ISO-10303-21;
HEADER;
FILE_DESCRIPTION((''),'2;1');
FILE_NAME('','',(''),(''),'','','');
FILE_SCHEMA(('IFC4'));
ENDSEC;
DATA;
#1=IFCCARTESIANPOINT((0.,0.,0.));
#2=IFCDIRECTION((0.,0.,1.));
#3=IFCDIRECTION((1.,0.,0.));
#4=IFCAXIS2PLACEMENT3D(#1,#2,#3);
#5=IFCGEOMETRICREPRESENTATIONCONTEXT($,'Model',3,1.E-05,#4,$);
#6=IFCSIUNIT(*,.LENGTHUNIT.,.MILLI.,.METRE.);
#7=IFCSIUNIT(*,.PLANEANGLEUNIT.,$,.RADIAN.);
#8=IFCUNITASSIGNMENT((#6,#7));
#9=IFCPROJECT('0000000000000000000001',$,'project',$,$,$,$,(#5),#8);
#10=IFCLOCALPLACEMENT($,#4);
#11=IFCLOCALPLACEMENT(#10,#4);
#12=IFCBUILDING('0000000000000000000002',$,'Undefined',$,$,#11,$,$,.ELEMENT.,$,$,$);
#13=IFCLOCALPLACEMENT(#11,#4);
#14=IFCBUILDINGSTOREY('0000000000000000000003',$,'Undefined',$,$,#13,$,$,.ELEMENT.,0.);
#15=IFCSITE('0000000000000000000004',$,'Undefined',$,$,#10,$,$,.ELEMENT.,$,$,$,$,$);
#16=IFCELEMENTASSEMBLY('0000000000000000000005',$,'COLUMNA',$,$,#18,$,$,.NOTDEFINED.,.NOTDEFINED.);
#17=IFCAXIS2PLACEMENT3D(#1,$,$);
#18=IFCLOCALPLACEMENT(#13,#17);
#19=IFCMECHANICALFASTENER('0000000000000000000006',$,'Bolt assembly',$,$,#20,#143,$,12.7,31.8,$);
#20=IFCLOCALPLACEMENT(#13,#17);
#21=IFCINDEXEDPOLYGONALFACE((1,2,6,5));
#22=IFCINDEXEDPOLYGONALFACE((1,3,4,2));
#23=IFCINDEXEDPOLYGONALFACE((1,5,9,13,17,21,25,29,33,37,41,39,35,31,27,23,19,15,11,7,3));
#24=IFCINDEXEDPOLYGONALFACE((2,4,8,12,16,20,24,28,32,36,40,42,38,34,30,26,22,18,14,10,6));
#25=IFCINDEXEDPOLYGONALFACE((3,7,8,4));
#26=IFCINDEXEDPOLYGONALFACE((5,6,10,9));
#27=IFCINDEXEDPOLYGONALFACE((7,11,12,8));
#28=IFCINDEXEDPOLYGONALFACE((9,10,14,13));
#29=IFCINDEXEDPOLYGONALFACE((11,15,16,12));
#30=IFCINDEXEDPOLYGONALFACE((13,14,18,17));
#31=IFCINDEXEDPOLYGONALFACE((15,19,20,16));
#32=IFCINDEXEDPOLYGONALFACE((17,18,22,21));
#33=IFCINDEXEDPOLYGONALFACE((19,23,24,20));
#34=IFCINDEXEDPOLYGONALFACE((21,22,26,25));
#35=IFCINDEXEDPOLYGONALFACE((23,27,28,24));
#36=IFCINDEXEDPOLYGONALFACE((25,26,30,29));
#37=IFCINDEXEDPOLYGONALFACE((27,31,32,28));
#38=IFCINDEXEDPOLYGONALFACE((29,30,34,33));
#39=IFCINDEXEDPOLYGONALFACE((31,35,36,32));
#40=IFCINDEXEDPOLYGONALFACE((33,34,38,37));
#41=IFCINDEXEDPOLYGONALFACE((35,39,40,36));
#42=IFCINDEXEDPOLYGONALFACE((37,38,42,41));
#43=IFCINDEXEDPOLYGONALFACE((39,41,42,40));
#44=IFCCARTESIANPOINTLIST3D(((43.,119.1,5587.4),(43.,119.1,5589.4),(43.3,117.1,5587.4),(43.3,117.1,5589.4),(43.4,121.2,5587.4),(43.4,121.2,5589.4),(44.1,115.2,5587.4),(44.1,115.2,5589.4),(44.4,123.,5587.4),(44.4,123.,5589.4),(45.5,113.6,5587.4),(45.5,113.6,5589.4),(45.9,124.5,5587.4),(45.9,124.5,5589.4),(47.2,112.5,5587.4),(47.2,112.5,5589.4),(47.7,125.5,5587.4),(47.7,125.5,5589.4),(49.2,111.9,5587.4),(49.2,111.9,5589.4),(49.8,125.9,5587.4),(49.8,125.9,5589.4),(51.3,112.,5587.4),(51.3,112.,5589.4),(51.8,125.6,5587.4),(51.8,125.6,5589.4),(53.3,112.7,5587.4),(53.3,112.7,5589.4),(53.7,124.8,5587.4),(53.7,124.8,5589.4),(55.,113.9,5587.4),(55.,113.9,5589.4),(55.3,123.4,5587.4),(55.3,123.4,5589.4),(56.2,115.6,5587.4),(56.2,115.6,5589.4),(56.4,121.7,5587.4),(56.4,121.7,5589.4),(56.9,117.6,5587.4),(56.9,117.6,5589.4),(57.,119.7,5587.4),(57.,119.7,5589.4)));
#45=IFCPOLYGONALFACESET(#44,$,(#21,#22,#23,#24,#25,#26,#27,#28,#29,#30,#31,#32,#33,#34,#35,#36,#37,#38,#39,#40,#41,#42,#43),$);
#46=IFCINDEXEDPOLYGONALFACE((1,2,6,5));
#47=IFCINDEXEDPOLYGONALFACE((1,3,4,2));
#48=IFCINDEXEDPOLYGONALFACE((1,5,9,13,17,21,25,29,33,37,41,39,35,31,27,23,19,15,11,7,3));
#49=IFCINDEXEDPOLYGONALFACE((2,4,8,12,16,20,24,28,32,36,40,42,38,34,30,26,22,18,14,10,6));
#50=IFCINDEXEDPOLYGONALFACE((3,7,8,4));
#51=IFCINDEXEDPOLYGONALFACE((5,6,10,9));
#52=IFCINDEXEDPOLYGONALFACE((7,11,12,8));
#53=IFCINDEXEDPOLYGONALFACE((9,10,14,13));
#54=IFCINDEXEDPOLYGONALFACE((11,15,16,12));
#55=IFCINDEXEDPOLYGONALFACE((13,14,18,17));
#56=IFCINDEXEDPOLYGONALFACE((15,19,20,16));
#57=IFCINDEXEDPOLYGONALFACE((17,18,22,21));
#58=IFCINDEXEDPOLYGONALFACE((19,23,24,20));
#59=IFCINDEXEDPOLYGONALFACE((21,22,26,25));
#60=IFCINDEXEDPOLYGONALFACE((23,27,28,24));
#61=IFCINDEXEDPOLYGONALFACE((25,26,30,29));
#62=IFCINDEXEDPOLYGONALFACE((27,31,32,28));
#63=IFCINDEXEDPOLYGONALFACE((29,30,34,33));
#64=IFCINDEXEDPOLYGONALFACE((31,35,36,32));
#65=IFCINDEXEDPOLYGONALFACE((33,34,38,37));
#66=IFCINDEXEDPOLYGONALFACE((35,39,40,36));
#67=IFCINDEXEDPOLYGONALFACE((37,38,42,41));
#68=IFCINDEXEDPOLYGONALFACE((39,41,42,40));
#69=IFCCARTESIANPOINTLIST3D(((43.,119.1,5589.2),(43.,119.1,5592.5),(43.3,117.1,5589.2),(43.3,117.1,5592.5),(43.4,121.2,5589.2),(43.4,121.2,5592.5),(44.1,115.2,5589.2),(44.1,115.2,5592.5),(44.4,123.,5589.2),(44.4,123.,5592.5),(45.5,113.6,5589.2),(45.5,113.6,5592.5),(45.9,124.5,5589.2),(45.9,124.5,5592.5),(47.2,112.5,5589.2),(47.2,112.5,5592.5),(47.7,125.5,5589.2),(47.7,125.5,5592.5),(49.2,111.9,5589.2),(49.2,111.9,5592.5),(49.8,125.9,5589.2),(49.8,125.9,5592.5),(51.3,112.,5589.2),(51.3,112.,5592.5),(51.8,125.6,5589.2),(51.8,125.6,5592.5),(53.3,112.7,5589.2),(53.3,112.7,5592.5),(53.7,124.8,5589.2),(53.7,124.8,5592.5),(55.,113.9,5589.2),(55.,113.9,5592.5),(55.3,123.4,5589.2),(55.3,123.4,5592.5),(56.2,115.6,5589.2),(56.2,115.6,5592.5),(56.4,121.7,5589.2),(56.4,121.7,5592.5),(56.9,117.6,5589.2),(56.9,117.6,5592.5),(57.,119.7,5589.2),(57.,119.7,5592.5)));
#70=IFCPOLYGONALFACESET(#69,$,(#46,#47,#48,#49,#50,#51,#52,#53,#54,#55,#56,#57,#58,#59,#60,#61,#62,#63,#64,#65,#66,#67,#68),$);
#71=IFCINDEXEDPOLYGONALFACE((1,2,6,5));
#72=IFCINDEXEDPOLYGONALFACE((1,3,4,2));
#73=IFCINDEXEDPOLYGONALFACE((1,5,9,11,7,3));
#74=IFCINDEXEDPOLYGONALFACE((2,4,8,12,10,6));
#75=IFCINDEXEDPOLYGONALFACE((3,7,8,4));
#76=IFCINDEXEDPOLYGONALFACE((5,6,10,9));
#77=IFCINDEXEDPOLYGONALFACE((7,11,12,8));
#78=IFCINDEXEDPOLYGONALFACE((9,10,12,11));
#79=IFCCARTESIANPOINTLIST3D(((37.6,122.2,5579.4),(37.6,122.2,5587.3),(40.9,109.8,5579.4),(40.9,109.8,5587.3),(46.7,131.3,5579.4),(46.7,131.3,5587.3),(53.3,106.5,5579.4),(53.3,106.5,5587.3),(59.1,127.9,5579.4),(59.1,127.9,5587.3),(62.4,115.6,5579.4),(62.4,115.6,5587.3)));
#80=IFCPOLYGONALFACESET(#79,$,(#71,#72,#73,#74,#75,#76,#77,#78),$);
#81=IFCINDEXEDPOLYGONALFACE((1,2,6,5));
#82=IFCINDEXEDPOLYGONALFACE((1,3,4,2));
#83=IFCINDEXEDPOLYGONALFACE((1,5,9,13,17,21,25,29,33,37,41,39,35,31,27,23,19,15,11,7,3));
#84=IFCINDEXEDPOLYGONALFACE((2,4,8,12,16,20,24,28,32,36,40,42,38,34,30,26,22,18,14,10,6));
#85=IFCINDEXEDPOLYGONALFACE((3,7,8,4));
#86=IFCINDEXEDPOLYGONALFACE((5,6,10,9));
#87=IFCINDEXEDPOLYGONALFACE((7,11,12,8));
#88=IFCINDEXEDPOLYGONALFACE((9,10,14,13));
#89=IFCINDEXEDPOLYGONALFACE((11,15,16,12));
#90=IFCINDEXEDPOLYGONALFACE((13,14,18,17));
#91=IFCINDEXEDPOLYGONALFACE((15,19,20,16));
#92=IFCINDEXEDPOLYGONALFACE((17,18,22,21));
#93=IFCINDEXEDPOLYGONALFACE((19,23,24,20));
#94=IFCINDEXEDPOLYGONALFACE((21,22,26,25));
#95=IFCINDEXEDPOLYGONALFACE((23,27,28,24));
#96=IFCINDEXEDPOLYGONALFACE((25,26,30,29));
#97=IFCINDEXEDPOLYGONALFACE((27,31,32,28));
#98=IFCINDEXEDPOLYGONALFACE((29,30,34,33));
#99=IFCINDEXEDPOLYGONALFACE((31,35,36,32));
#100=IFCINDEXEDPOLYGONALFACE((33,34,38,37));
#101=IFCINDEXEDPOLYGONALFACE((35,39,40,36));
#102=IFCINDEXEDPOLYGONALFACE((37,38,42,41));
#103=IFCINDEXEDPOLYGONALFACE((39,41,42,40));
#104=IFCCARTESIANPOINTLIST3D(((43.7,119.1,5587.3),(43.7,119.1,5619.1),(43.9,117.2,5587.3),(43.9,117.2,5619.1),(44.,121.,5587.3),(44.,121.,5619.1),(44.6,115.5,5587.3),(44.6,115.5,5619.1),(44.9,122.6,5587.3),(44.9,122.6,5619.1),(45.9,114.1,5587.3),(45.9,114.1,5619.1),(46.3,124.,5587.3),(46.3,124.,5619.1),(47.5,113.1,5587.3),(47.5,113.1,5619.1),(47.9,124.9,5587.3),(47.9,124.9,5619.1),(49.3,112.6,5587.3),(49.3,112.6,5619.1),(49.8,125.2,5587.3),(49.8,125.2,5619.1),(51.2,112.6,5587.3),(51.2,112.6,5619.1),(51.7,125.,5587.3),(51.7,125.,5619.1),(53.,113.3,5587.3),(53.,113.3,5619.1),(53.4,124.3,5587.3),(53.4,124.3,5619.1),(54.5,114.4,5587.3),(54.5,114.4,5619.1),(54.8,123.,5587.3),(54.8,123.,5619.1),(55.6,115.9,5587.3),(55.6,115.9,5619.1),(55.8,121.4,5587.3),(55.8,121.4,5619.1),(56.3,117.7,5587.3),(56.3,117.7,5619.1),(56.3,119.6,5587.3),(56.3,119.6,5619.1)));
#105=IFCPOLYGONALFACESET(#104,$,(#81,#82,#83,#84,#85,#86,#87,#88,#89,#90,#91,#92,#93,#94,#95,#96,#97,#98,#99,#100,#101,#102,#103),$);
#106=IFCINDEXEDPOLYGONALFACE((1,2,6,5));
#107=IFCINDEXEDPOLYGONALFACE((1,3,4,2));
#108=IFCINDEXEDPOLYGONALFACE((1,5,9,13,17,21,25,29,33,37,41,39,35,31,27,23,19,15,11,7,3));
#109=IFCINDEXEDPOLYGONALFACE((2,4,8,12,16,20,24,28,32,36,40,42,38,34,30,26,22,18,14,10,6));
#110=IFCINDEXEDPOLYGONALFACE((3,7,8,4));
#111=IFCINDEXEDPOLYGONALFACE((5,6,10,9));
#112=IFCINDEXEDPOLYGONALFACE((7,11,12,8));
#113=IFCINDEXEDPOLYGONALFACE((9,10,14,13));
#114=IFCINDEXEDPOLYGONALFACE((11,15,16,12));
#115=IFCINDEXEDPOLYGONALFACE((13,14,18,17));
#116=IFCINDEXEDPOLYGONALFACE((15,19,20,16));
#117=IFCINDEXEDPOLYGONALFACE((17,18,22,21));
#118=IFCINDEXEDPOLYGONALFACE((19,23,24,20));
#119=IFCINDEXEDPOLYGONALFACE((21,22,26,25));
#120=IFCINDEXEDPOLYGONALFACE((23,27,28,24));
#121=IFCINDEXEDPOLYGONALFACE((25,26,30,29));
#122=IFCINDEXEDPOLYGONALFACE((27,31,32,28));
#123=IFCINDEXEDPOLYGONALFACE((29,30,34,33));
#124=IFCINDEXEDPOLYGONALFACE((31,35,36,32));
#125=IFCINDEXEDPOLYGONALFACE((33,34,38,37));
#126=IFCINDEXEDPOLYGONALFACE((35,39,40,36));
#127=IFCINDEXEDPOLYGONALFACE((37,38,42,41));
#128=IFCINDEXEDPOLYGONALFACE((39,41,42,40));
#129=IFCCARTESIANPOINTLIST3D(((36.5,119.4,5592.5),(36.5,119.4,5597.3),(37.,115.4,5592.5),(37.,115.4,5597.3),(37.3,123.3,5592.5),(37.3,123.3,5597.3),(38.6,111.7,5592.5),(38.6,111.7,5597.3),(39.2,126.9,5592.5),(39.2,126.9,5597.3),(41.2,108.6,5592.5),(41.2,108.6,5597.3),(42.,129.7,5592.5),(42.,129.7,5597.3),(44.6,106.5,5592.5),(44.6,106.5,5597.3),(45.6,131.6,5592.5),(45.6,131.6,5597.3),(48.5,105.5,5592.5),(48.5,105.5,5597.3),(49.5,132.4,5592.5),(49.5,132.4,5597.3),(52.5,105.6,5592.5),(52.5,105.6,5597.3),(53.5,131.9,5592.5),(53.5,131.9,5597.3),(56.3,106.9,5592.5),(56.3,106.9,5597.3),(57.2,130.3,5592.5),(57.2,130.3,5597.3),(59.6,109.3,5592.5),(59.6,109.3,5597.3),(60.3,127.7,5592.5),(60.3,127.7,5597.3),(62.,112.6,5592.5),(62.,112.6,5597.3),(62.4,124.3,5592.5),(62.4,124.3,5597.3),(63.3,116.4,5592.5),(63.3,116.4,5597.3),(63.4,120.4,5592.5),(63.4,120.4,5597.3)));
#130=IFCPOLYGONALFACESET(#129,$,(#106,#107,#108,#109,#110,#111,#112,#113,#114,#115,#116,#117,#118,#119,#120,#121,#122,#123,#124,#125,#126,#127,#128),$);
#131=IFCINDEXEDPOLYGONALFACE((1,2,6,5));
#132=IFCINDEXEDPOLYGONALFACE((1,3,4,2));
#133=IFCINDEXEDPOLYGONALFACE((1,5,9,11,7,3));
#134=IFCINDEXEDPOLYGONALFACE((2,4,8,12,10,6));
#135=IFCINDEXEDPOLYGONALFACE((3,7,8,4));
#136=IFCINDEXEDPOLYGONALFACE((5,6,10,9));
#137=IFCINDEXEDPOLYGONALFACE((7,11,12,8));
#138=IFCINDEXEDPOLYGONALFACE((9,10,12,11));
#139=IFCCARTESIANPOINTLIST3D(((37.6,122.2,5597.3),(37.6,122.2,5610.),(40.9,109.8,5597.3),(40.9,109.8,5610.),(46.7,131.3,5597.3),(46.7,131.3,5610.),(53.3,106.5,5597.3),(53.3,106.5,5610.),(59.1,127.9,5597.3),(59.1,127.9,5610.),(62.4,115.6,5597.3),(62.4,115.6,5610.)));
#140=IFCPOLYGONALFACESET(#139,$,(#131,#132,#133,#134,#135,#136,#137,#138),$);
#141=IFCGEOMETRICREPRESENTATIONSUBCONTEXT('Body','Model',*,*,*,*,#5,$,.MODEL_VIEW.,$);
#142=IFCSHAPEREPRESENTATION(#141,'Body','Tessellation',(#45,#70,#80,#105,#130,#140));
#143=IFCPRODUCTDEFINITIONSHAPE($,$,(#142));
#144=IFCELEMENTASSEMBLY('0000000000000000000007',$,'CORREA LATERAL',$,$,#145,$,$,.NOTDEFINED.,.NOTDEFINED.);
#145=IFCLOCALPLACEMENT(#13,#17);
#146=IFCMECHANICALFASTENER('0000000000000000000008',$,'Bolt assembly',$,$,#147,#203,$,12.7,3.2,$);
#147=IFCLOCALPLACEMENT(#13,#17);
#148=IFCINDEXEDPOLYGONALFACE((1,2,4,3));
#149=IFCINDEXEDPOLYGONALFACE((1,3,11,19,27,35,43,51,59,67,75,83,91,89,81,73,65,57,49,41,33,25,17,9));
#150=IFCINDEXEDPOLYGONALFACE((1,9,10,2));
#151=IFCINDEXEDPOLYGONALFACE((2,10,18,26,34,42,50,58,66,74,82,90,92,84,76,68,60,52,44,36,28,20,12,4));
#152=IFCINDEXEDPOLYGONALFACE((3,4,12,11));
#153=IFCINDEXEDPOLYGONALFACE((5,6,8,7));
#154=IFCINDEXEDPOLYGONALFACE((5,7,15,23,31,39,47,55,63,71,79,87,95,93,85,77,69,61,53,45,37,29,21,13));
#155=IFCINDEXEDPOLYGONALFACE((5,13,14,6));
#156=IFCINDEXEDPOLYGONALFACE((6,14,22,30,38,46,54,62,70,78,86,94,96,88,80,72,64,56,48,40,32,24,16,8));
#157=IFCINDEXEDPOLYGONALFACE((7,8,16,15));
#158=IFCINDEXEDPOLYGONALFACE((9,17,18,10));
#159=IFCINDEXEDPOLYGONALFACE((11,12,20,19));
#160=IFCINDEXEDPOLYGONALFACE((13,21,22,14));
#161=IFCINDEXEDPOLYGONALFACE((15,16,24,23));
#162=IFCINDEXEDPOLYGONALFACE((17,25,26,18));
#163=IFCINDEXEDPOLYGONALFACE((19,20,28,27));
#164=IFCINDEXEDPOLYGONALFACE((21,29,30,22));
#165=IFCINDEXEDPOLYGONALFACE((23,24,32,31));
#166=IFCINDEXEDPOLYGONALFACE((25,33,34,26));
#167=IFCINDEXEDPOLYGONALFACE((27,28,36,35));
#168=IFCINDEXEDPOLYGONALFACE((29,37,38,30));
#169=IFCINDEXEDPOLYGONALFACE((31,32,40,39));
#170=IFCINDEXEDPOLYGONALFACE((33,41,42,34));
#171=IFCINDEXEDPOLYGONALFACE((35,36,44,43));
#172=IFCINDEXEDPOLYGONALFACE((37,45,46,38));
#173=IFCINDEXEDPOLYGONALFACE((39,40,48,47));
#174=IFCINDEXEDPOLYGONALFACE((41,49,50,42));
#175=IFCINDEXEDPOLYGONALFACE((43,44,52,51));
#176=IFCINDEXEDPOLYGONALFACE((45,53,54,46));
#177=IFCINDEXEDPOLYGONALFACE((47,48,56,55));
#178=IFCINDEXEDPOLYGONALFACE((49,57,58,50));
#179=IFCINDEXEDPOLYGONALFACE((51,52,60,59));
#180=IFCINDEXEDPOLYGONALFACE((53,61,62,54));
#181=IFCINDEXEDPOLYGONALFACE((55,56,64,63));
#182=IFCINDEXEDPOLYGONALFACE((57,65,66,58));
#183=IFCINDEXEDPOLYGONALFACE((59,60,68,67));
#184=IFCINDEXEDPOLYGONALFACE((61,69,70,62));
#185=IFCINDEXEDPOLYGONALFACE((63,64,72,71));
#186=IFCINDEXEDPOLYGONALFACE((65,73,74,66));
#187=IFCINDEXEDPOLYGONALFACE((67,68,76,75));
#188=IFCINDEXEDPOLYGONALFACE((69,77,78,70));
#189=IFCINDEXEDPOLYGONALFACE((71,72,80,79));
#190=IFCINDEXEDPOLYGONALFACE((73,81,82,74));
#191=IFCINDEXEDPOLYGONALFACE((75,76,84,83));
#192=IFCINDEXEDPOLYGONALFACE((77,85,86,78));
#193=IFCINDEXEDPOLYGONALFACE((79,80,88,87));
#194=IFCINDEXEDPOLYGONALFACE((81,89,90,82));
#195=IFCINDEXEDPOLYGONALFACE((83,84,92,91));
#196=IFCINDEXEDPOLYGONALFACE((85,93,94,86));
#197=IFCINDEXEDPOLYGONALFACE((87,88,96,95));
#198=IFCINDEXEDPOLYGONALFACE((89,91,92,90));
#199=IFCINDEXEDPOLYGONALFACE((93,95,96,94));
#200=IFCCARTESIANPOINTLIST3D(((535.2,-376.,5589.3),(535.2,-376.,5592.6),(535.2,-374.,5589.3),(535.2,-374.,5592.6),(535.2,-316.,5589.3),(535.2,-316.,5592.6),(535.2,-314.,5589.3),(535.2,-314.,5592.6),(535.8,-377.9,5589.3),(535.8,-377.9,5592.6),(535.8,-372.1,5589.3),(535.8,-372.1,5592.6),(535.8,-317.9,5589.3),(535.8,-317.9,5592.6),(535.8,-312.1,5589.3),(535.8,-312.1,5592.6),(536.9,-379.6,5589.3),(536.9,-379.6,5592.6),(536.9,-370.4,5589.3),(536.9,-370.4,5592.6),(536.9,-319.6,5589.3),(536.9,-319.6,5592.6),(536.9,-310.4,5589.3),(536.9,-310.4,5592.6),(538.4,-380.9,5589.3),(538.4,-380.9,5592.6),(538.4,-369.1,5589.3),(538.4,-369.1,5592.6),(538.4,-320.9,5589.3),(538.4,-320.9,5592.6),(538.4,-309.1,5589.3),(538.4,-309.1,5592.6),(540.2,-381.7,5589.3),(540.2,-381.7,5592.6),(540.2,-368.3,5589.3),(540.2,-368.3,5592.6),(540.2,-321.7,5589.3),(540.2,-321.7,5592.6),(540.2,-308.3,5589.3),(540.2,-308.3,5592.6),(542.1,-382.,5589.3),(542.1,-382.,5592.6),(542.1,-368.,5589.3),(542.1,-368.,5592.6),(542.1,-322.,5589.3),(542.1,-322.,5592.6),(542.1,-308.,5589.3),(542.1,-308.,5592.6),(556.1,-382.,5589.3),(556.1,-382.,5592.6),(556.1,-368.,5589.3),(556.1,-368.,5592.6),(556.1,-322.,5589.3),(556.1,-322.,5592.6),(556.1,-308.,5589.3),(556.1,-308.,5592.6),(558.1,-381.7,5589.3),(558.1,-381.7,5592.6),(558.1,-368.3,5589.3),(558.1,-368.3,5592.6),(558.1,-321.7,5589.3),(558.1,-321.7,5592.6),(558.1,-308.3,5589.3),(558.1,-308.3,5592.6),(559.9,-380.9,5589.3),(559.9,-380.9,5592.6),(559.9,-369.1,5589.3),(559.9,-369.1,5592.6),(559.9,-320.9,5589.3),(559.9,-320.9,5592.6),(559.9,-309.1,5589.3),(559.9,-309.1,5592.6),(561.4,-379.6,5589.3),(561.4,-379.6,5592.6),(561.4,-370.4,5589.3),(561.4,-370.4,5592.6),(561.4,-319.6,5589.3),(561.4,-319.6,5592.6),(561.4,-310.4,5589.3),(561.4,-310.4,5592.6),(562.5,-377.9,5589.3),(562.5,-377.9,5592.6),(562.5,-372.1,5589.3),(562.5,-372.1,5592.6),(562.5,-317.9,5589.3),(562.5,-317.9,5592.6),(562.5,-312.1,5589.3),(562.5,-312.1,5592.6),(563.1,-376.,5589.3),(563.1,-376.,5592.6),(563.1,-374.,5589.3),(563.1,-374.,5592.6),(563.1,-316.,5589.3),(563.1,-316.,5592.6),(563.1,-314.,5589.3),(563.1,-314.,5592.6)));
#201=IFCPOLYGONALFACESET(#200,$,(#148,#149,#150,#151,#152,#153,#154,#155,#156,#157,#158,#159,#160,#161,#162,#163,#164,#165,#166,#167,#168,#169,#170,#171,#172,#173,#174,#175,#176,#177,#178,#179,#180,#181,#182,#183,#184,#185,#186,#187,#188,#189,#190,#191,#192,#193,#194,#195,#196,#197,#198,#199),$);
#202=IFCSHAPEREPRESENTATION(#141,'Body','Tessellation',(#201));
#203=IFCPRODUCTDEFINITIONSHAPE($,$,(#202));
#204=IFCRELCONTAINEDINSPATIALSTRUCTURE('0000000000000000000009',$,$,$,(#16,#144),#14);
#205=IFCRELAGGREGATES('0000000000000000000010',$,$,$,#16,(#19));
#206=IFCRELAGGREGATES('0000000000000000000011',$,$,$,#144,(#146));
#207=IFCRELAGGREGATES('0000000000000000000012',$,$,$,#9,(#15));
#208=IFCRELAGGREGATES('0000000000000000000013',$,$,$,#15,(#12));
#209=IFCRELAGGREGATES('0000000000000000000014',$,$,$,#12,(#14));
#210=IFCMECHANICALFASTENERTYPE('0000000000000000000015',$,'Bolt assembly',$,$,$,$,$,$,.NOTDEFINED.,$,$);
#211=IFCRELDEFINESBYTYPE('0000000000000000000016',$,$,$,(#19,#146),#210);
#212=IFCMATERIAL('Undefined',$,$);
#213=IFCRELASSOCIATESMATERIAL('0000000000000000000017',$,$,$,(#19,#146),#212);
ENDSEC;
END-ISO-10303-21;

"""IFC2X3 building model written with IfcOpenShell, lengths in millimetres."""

from ifc_helpers import new_model, si_unit, frame, frame_2d, origin_with_axes, origin_2d_with_axis, place, context, subcontext, project, spatial, polyline, circle_curve, parameter, trimmed, segment, composite_curve, circle, outline, extrude, source, transform, mapped, material, type_object, element, aggregate, save


model = new_model("IFC2X3")

# Units and contexts
model_context = context("Model", 3, precision=1e-05, world=origin_with_axes())
body_context = subcontext(model_context, "Body", "Model", "MODEL_VIEW")
ifc_project = project(units=[si_unit("LENGTHUNIT", "METRE", prefix="MILLI"), si_unit("PLANEANGLEUNIT", "RADIAN")], contexts=[model_context])

# Site, building, storey
site_placement = place(None, origin_with_axes())
site = spatial("IfcSite", under=ifc_project, at=site_placement, Name="Undefined", CompositionType="ELEMENT")
building_placement = place(site_placement, origin_with_axes())
building = spatial("IfcBuilding", under=site, at=building_placement, Name="Undefined", CompositionType="ELEMENT")
storey_placement = place(building_placement, origin_with_axes())
storey = spatial("IfcBuildingStorey", under=building, at=storey_placement, Name="Undefined", CompositionType="ELEMENT", Elevation=0.0)

# Element assembly
assembly_1_placement = place(storey_placement, origin_with_axes())
assembly_1 = element("IfcElementAssembly", 1, at=assembly_1_placement, inside=storey, Name="COLUMNA", AssemblyPlace="NOTDEFINED", PredefinedType="NOTDEFINED")

# Shared definitions
ifc_material_1 = material(Name="Undefined")
mechanical_fastener_type = type_object("IfcMechanicalFastenerType", Name="Bolt assembly")

# Mechanical fastener
shared_shape_1 = source(origin_with_axes(), body_context, "Body", "SweptSolid", [
    extrude(circle(Radius=7.0, at=origin_2d_with_axis()), frame((0.0, -1.9, 0.0), z_axis=(0.0, 1.0, 0.0), x_axis=(1.0, 0.0, 0.0)), (0.0, 0.0, 1.0), 2.0),
    extrude(circle(Radius=7.0, at=origin_2d_with_axis()), frame((0.0, -0.1, 0.0), z_axis=(0.0, 1.0, 0.0), x_axis=(1.0, 0.0, 0.0)), (0.0, 0.0, 1.0), 3.3),
    extrude(outline(polyline([(11.1, -6.4), (11.1, 6.4), (0.0, 12.8), (-11.1, 6.4), (-11.1, -6.4), (0.0, -12.8), (11.1, -6.4)])), frame((0.0, -9.9, 0.0), z_axis=(0.0, 1.0, 0.0), x_axis=(1.0, 0.0, 0.0)), (0.0, 0.0, 1.0), 7.9),
    extrude(circle(Radius=6.3, at=origin_2d_with_axis()), frame((0.0, -2.0, 0.0), z_axis=(0.0, 1.0, 0.0), x_axis=(1.0, 0.0, 0.0)), (0.0, 0.0, 1.0), 31.8),
    extrude(circle(Radius=13.5, at=origin_2d_with_axis()), frame((0.0, 3.2, 0.0), z_axis=(0.0, 1.0, 0.0), x_axis=(1.0, 0.0, 0.0)), (0.0, 0.0, 1.0), 4.8),
    extrude(outline(polyline([(11.1, -6.4), (11.1, 6.4), (0.0, 12.8), (-11.1, 6.4), (-11.1, -6.4), (0.0, -12.8), (11.1, -6.4)])), frame((0.0, 8.0, 0.0), z_axis=(0.0, 1.0, 0.0), x_axis=(1.0, 0.0, 0.0)), (0.0, 0.0, 1.0), 12.7),
])
mechanical_fastener_1_placement = place(assembly_1_placement, frame((50.0, 118.9, 5589.3), z_axis=(-0.707106, -0.707107, 0.000005), x_axis=(0.707107, -0.707107, 0.000005)))
mechanical_fastener_1 = element("IfcMechanicalFastener", 2, at=mechanical_fastener_1_placement, type_object=mechanical_fastener_type, material=ifc_material_1, Name="Bolt assembly", NominalDiameter=12.7, NominalLength=31.8, context=body_context, shape_type="MappedRepresentation", body=[
    mapped(shared_shape_1, transform((0.0, 0.0, 0.0))),
])
aggregate(assembly_1, [mechanical_fastener_1])

# Element assembly, mechanical fastener
assembly_2_placement = place(storey_placement, origin_with_axes())
assembly_2 = element("IfcElementAssembly", 3, at=assembly_2_placement, inside=storey, Name="CORREA LATERAL", AssemblyPlace="NOTDEFINED", PredefinedType="NOTDEFINED")
shared_shape_2 = source(origin_with_axes(), body_context, "Body", "SweptSolid", [
    extrude(outline(composite_curve([segment(polyline([(7.0, 7.0), (7.0, -7.0)]), True, "CONTINUOUS"), segment(trimmed(circle_curve(frame_2d((0.0, -7.0), x_axis=(1.0, 0.0)), 7.0), [parameter(0.0)], [parameter(3.141593)], False, "PARAMETER"), True, "CONTINUOUS"), segment(polyline([(-7.0, -7.0), (-7.0, 7.0)]), True, "CONTINUOUS"), segment(trimmed(circle_curve(frame_2d((0.0, 7.0), x_axis=(-1.0, 0.0)), 7.0), [parameter(0.0)], [parameter(3.141593)], False, "PARAMETER"), True, "DISCONTINUOUS")], self_intersect=False)), frame((0.0, 0.0, 0.0), z_axis=(0.0, 1.0, 0.0), x_axis=(1.0, 0.0, 0.0)), (0.0, 0.0, 1.0), 3.3),
])
mechanical_fastener_2_placement = place(assembly_2_placement, frame((549.1, -375.0, 5589.3), z_axis=(1.0, 0.0, 0.0), x_axis=(0.0, 1.0, 0.000007)))
mechanical_fastener_2 = element("IfcMechanicalFastener", 4, at=mechanical_fastener_2_placement, type_object=mechanical_fastener_type, material=ifc_material_1, Name="Bolt assembly", NominalDiameter=12.7, NominalLength=3.2, context=body_context, shape_type="MappedRepresentation", body=[
    mapped(shared_shape_2, transform((0.0, 0.0, 0.0))),
    mapped(shared_shape_2, transform((60.0, 0.0, 0.0))),
])

aggregate(assembly_2, [mechanical_fastener_2])

save(model, "model.ifc")
